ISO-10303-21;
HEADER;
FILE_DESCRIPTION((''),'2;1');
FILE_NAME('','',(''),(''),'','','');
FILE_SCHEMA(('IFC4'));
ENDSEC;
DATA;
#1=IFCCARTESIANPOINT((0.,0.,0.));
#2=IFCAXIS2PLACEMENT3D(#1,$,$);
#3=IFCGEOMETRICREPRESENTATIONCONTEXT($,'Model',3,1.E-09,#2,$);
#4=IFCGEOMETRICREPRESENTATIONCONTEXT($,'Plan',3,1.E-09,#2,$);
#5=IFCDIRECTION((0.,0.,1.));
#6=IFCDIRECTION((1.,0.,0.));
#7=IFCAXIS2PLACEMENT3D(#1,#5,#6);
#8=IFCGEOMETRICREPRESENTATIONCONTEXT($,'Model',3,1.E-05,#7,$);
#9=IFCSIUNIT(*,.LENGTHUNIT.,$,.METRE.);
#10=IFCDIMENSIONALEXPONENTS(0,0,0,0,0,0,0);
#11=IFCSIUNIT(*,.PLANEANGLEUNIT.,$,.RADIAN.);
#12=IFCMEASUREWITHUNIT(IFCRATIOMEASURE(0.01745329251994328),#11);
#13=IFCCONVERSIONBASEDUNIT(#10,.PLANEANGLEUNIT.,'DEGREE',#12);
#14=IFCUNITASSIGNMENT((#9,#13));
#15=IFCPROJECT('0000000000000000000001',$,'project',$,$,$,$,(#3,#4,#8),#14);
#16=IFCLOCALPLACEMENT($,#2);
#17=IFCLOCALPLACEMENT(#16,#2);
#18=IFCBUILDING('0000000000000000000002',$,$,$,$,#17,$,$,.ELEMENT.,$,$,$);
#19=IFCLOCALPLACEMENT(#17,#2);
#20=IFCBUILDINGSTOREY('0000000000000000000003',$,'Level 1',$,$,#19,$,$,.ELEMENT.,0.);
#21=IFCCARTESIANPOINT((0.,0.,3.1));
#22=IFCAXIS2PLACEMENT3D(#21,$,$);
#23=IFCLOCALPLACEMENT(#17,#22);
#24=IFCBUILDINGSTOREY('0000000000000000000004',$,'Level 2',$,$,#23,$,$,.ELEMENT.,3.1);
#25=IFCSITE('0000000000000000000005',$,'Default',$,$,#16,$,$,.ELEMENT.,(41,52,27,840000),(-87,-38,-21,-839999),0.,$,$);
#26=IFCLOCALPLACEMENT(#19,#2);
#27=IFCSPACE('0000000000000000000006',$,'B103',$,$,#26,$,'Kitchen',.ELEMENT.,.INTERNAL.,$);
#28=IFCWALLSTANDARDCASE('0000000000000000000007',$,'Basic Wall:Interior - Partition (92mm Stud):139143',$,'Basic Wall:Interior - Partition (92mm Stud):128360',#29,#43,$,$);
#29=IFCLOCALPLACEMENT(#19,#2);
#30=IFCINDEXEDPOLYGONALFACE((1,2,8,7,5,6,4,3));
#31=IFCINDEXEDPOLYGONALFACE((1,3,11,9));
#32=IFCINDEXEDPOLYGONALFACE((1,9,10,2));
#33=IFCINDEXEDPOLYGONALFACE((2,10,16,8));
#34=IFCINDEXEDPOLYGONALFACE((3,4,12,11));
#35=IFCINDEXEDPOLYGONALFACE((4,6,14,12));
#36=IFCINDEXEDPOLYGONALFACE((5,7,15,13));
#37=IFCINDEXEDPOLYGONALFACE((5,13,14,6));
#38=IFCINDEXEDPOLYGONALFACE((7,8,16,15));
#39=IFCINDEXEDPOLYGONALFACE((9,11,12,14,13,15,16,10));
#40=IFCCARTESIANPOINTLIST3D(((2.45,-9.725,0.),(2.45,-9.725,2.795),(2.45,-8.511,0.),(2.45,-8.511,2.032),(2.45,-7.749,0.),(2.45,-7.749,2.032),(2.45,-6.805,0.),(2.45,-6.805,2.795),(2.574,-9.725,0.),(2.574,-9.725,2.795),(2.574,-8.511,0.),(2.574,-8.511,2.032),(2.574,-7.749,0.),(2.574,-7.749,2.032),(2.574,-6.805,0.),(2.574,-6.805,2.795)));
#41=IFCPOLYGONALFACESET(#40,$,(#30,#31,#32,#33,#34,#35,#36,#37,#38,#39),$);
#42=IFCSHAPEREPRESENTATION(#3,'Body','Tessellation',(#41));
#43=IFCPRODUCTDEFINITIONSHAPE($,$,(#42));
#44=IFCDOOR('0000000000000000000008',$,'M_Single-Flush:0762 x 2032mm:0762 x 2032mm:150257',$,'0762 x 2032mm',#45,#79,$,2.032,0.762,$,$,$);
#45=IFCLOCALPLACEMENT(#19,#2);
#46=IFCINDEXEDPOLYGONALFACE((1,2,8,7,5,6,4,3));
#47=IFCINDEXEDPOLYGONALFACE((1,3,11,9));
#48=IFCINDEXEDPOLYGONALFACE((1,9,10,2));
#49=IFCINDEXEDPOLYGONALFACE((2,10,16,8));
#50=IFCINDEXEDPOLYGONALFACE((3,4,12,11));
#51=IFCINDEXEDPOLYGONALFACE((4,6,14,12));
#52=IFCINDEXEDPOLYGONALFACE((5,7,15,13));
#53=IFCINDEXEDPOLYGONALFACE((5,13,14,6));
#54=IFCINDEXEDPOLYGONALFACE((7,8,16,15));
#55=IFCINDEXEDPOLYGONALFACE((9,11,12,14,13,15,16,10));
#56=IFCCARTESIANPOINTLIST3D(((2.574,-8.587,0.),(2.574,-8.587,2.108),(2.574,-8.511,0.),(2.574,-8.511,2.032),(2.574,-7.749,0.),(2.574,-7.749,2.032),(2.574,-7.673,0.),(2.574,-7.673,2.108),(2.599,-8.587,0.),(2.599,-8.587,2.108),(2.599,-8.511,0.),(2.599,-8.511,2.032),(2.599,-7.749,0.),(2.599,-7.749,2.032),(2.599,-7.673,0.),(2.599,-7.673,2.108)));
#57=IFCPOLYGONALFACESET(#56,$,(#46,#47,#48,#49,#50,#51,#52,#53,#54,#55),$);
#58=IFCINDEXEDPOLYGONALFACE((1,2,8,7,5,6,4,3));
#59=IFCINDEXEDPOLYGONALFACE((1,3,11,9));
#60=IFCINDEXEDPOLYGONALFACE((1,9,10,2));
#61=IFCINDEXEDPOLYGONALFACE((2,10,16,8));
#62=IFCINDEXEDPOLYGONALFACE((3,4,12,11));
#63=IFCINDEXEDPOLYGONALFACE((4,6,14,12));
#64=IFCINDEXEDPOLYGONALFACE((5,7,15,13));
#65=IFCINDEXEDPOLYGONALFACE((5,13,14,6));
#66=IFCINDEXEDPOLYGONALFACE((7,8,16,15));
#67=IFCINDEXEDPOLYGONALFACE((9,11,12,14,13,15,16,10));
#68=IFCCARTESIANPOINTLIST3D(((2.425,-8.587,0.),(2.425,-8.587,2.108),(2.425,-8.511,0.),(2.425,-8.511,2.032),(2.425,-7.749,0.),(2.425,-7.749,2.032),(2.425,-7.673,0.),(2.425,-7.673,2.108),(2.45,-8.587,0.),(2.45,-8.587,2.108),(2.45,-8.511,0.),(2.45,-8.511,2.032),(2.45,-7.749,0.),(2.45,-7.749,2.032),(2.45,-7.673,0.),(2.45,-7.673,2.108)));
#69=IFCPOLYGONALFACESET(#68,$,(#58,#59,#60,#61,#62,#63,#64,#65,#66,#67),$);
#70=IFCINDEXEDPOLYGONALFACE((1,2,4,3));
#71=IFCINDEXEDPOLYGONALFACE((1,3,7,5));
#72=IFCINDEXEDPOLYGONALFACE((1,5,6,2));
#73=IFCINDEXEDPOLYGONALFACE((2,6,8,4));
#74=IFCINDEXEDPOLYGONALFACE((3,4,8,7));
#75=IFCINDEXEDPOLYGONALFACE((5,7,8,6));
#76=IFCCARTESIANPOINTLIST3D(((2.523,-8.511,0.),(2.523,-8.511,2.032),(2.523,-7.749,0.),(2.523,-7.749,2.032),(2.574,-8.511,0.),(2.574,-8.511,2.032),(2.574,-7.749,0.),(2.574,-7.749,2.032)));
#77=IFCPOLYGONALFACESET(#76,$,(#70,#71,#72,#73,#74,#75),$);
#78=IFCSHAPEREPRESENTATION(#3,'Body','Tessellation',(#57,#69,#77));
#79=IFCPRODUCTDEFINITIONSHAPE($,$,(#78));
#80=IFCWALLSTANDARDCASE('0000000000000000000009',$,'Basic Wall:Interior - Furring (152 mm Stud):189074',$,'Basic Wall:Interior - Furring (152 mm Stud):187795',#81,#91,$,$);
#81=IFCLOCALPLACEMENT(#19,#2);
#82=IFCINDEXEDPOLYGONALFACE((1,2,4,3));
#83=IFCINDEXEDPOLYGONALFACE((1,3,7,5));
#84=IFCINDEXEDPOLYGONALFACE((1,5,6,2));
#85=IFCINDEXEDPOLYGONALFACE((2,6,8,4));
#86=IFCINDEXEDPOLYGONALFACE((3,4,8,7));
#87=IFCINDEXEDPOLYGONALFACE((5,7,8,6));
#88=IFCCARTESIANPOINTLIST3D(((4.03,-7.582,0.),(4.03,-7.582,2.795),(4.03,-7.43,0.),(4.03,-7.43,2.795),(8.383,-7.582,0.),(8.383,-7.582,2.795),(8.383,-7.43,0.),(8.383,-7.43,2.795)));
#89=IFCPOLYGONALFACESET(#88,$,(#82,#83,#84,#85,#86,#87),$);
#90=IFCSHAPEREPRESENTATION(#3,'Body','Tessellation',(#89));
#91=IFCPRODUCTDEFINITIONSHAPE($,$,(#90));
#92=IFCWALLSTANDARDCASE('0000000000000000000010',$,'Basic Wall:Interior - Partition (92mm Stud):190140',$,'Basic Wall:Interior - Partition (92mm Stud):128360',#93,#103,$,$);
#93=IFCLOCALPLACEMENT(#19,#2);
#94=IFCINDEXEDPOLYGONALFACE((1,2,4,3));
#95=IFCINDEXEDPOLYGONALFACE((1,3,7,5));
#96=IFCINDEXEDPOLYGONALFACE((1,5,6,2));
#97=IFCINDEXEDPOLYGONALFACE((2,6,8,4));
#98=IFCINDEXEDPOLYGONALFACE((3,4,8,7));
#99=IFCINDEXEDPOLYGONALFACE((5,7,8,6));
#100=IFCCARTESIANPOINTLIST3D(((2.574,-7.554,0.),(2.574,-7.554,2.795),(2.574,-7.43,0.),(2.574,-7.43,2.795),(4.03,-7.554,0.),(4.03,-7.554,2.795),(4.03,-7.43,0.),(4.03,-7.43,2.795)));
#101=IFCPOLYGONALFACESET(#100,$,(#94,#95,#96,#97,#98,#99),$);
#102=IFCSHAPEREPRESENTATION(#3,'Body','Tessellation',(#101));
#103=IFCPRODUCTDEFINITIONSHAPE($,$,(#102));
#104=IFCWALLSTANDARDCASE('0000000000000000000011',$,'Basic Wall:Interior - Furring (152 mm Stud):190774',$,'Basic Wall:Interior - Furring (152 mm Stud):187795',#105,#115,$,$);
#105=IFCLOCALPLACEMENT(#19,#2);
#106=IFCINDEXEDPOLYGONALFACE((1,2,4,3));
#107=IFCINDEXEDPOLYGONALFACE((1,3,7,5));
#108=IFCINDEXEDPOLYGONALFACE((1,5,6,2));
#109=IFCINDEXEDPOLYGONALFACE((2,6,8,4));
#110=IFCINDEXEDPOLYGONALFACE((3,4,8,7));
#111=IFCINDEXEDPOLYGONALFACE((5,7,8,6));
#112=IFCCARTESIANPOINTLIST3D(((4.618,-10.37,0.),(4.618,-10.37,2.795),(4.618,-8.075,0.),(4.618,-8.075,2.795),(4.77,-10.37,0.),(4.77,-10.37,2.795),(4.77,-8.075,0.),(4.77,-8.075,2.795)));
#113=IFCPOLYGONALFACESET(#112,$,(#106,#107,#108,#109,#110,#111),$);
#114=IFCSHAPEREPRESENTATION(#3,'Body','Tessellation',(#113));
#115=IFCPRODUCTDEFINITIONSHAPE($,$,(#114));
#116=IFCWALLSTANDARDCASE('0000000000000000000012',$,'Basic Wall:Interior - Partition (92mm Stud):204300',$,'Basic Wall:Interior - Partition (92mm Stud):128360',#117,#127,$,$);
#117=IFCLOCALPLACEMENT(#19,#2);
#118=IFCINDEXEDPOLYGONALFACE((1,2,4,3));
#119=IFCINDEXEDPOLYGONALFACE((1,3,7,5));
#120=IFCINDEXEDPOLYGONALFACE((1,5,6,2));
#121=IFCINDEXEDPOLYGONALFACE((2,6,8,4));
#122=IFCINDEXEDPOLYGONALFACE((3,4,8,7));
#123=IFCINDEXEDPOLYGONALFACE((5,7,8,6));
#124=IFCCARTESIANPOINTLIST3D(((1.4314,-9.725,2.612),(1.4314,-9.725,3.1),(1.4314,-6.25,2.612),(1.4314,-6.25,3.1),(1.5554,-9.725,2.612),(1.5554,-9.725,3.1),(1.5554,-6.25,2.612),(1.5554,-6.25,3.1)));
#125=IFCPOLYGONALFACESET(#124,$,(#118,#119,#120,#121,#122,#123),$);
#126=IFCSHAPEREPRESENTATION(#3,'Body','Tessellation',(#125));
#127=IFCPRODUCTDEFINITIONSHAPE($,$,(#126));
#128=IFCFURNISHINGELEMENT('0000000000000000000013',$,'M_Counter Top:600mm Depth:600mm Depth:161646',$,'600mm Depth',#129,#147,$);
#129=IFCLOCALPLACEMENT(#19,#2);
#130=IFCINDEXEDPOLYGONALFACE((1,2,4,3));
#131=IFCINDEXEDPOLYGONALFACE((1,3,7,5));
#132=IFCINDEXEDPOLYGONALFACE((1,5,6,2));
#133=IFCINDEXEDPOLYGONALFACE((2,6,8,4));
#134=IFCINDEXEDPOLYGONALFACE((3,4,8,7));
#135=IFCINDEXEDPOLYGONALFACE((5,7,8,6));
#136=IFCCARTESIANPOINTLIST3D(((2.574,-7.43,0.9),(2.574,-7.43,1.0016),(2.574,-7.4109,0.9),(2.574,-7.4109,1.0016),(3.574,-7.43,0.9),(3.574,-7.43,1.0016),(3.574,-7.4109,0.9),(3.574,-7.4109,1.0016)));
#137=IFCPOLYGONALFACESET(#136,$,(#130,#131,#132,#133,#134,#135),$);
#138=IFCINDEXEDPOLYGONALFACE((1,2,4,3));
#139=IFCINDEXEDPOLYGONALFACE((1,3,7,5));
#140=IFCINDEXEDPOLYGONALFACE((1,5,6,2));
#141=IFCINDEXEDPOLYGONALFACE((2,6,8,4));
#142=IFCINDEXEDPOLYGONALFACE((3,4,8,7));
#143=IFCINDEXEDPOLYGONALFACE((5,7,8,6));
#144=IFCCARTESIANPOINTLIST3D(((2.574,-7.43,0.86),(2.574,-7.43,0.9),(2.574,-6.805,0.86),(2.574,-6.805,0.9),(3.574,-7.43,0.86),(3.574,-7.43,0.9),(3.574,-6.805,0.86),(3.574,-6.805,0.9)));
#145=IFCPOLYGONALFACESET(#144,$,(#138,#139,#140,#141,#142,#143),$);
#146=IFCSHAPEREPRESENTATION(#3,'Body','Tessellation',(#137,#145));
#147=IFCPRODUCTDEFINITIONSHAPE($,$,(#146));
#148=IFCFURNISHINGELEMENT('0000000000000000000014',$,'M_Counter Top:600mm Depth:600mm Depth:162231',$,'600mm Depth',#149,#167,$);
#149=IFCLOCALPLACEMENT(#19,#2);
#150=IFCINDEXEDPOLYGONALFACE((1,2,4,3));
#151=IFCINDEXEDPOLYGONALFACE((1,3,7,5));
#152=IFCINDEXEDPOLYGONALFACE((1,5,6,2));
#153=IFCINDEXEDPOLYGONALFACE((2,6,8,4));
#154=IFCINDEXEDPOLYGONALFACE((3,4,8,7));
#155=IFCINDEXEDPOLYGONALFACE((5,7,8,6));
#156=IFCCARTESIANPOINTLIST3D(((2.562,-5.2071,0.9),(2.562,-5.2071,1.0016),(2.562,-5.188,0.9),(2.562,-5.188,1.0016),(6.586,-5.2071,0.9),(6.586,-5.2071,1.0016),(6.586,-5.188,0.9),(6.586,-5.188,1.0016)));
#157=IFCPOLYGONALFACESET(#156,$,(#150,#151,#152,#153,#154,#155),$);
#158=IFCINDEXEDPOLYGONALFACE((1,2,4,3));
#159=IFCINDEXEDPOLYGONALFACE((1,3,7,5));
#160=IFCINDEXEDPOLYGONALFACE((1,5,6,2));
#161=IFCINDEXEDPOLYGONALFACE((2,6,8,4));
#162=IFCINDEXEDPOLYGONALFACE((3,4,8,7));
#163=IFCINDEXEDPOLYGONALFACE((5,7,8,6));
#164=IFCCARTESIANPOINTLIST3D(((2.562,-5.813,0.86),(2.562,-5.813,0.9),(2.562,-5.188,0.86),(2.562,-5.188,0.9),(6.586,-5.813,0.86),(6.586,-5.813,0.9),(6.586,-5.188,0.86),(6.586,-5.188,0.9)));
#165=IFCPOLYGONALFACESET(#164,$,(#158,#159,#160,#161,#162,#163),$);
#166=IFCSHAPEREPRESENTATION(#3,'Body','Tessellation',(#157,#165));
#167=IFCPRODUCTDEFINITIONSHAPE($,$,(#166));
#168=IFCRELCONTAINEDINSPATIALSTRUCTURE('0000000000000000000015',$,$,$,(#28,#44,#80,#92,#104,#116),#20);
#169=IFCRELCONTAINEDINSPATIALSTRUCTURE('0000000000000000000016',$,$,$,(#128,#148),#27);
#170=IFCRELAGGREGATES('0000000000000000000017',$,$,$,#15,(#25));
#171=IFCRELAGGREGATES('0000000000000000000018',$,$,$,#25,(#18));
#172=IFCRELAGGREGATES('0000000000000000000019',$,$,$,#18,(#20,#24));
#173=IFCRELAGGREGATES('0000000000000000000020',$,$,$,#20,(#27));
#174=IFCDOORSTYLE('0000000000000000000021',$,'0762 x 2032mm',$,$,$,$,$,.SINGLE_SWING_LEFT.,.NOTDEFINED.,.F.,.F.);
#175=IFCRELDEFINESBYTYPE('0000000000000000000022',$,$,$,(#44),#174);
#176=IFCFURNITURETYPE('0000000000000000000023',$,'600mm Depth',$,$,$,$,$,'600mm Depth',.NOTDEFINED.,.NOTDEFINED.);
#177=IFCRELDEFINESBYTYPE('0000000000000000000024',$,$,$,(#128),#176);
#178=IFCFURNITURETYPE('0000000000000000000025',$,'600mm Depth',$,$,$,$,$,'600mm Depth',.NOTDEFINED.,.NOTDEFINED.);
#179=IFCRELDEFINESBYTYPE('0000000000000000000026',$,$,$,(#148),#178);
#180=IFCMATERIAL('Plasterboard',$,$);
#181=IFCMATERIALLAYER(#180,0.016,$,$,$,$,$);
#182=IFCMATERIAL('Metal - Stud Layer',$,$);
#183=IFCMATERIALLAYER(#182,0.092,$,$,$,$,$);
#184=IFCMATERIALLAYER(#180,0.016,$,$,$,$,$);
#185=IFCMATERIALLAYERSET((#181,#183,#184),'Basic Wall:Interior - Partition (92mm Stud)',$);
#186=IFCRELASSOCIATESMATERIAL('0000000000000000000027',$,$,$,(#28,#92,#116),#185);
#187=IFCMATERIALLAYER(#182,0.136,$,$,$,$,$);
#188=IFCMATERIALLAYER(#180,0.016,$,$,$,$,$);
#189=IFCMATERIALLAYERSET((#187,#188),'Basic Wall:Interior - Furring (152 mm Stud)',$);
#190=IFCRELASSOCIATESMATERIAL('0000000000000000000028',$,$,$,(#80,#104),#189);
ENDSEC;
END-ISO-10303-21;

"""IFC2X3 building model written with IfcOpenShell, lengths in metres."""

from ifc_helpers import new_model, entity, si_unit, converted_unit, frame, frame_2d, origin, origin_with_axes, origin_2d_with_axis, place, context, project, spatial, polyline, rectangle, outline, extrude, clip, bounded_halfspace, source, transform, mapped, material, layer, layer_set, layer_usage, type_object, type_shapes, element, fill, save


model = new_model("IFC2X3")

# Units and contexts
model_context_1 = context("Model", 3, precision=1e-09, world=origin())
plan_context = context("Plan", 3, precision=1e-09, world=origin())
model_context_2 = context("Model", 3, precision=1e-05, world=origin_with_axes())
ifc_project = project(units=[si_unit("LENGTHUNIT", "METRE"), converted_unit("PLANEANGLEUNIT", "DEGREE", entity("IfcRatioMeasure", 0.01745329251994328), si_unit("PLANEANGLEUNIT", "RADIAN"), dimensions=[0, 0, 0, 0, 0, 0, 0])], contexts=[model_context_1, plan_context, model_context_2])

# Site, building, storey
site_placement = place(None, origin())
site = spatial("IfcSite", under=ifc_project, at=site_placement, Name="Default", CompositionType="ELEMENT", RefLatitude=(41, 52, 27, 840000), RefLongitude=(-87, -38, -21, -839999), RefElevation=0.0)
building_placement = place(site_placement, origin())
building = spatial("IfcBuilding", under=site, at=building_placement, CompositionType="ELEMENT")
storey_1_placement = place(building_placement, origin())
storey_1 = spatial("IfcBuildingStorey", under=building, at=storey_1_placement, Name="Level 1", CompositionType="ELEMENT", Elevation=0.0)

# Shared definitions
ifc_material_1 = material(Name="Metal - Stud Layer")
ifc_material_2 = material(Name="Plasterboard")

# Shared definitions
ifc_layer_1 = layer(ifc_material_2, 0.016)
ifc_layer_2 = layer(ifc_material_1, 0.092)
ifc_layer_3 = layer(ifc_material_2, 0.016)
ifc_layer_set_1 = layer_set([ifc_layer_1, ifc_layer_2, ifc_layer_3], Name="Basic Wall:Interior - Partition (92mm Stud)")

# Wall, opening, door
ifc_layer_usage_1 = layer_usage(ifc_layer_set_1, "AXIS2", "NEGATIVE", 0.062)
wall_1_placement = place(storey_1_placement, frame((2.512, -6.805, 0.0), z_axis=(0.0, 0.0, 1.0), x_axis=(0.0, -1.0, 0.0)))
wall_1 = element("IfcWallStandardCase", 1, at=wall_1_placement, inside=storey_1, material=ifc_layer_usage_1, Name="Basic Wall:Interior - Partition (92mm Stud):139143", ObjectType="Basic Wall:Interior - Partition (92mm Stud):128360", context=model_context_1, shape_type="SweptSolid", body=[
    extrude(rectangle(XDim=2.92, YDim=0.124, at=frame_2d((1.46, 0.0), x_axis=(-1.0, 0.0))), origin(), (0.0, 0.0, 1.0), 2.795),
])
opening_1_placement = place(wall_1_placement, frame((0.944, -0.062, 0.0)))
opening_1 = element("IfcOpeningElement", 2, at=opening_1_placement, cuts=wall_1, ObjectType="Opening", context=model_context_1, shape_type="SweptSolid", body=[
    extrude(rectangle(XDim=0.762, YDim=2.032, at=frame_2d((1.016, 0.381), x_axis=(0.0, -1.0))), frame((0.0, 0.0, 0.0), z_axis=(0.0, 1.0, 0.0), x_axis=(0.0, 0.0, 1.0)), (0.0, 0.0, 1.0), 0.124),
])
door_style_1 = type_object("IfcDoorStyle", Name="0762 x 2032mm", ConstructionType="NOTDEFINED", OperationType="SINGLE_SWING_LEFT", ParameterTakesPrecedence=False, Sizeable=False)
shared_shape_1 = source(origin(), model_context_1, "Body", "SweptSolid", [
    extrude(outline(polyline([(-0.457, -1.073), (0.457, -1.073), (0.457, 1.035), (0.381, 1.035), (0.381, -0.997), (-0.381, -0.997), (-0.381, 1.035), (-0.457, 1.035), (-0.457, -1.073)])), frame((0.381, 0.149, 1.035), z_axis=(0.0, -1.0, 0.0), x_axis=(-1.0, 0.0, 0.0)), (0.0, 0.0, 1.0), 0.025),
    extrude(outline(polyline([(-1.073, -0.457), (1.035, -0.457), (1.035, -0.381), (-0.997, -0.381), (-0.997, 0.381), (1.035, 0.381), (1.035, 0.457), (-1.073, 0.457), (-1.073, -0.457)])), frame((0.381, 0.0, 1.035), z_axis=(0.0, -1.0, 0.0), x_axis=(0.0, 0.0, -1.0)), (0.0, 0.0, 1.0), 0.025),
    extrude(rectangle(XDim=0.762, YDim=0.051, at=origin_2d_with_axis()), frame((0.381, 0.0985, 0.0)), (0.0, 0.0, 1.0), 2.032),
])
type_shapes(door_style_1, [shared_shape_1])
door_1_placement = place(opening_1_placement, origin())
door_1 = element("IfcDoor", 3, at=door_1_placement, inside=storey_1, type_object=door_style_1, Name="M_Single-Flush:0762 x 2032mm:0762 x 2032mm:150257", ObjectType="0762 x 2032mm", OverallHeight=2.032, OverallWidth=0.762, context=model_context_1, shape_type="MappedRepresentation", body=[
    mapped(shared_shape_1, transform((0.0, 0.0, 0.0), scale=1.0)),
])
fill(opening_1, door_1)

# Shared definitions
storey_2_placement = place(building_placement, frame((0.0, 0.0, 3.1)))
storey_2 = spatial("IfcBuildingStorey", under=building, at=storey_2_placement, Name="Level 2", CompositionType="ELEMENT", Elevation=3.1)

# Walls
ifc_layer_4 = layer(ifc_material_1, 0.136)
ifc_layer_5 = layer(ifc_material_2, 0.016)
ifc_layer_set_2 = layer_set([ifc_layer_4, ifc_layer_5], Name="Basic Wall:Interior - Furring (152 mm Stud)")
ifc_layer_usage_2 = layer_usage(ifc_layer_set_2, "AXIS2", "NEGATIVE", 0.076)
wall_2_placement = place(storey_1_placement, frame((8.383, -7.506, 0.0), z_axis=(0.0, 0.0, 1.0), x_axis=(-1.0, 0.0, 0.0)))
element("IfcWallStandardCase", 4, at=wall_2_placement, inside=storey_1, material=ifc_layer_usage_2, Name="Basic Wall:Interior - Furring (152 mm Stud):189074", ObjectType="Basic Wall:Interior - Furring (152 mm Stud):187795", context=model_context_1, shape_type="Clipping", body=[
    clip(extrude(rectangle(XDim=4.353, YDim=0.152, at=frame_2d((2.1765, 0.0), x_axis=(-1.0, 0.0))), origin(), (0.0, 0.0, 1.0), 2.795), bounded_halfspace(frame((0.0, -0.076, 2.795), z_axis=(0.0, 0.0, -1.0), x_axis=(0.0, 1.0, 0.0)), True, frame((0.0, -0.076, 2.795)), polyline([(0.0, 0.0), (3.708, 0.0), (3.708, 0.152), (0.0, 0.152), (0.0, 0.0)]))),
])
ifc_layer_usage_3 = layer_usage(ifc_layer_set_1, "AXIS2", "NEGATIVE", 0.062)
wall_3_placement = place(storey_1_placement, frame((4.03, -7.492, 0.0), z_axis=(0.0, 0.0, 1.0), x_axis=(-1.0, 0.0, 0.0)))
element("IfcWallStandardCase", 5, at=wall_3_placement, inside=storey_1, material=ifc_layer_usage_3, Name="Basic Wall:Interior - Partition (92mm Stud):190140", ObjectType="Basic Wall:Interior - Partition (92mm Stud):128360", context=model_context_1, shape_type="SweptSolid", body=[
    extrude(rectangle(XDim=1.456, YDim=0.124, at=frame_2d((0.728, 0.0), x_axis=(-1.0, 0.0))), origin(), (0.0, 0.0, 1.0), 2.795),
])
ifc_layer_usage_4 = layer_usage(ifc_layer_set_2, "AXIS2", "POSITIVE", -0.076)
wall_4_placement = place(storey_1_placement, frame((4.694, -8.075, 0.0), z_axis=(0.0, 0.0, 1.0), x_axis=(0.0, -1.0, 0.0)))
element("IfcWallStandardCase", 6, at=wall_4_placement, inside=storey_1, material=ifc_layer_usage_4, Name="Basic Wall:Interior - Furring (152 mm Stud):190774", ObjectType="Basic Wall:Interior - Furring (152 mm Stud):187795", context=model_context_1, shape_type="SweptSolid", body=[
    extrude(rectangle(XDim=2.295, YDim=0.152, at=frame_2d((1.1475, 0.0), x_axis=(-1.0, 0.0))), origin(), (0.0, 0.0, 1.0), 2.795),
])
ifc_layer_usage_5 = layer_usage(ifc_layer_set_1, "AXIS2", "NEGATIVE", 0.062)
wall_5_placement = place(storey_1_placement, frame((1.4934, -6.25, 2.612), z_axis=(0.0, 0.0, 1.0), x_axis=(0.0, -1.0, 0.0)))
element("IfcWallStandardCase", 7, at=wall_5_placement, inside=storey_1, material=ifc_layer_usage_5, Name="Basic Wall:Interior - Partition (92mm Stud):204300", ObjectType="Basic Wall:Interior - Partition (92mm Stud):128360", context=model_context_1, shape_type="SweptSolid", body=[
    extrude(rectangle(XDim=3.475, YDim=0.124, at=frame_2d((1.7375, 0.0), x_axis=(-1.0, 0.0))), origin(), (0.0, 0.0, 1.0), 0.488),
])

# Shared definitions
space_1_placement = place(storey_1_placement, origin())
space_1 = spatial("IfcSpace", under=storey_1, at=space_1_placement, Name="B103", LongName="Kitchen", CompositionType="ELEMENT", InteriorOrExteriorSpace="INTERNAL")

# Furnishing elements
furniture_type_1 = type_object("IfcFurnitureType", Name="600mm Depth", ElementType="600mm Depth", AssemblyPlace="NOTDEFINED")
shared_shape_2 = source(origin(), model_context_1, "Body", "SweptSolid", [
    extrude(rectangle(XDim=0.0191, YDim=1.0, at=origin_2d_with_axis()), frame((-0.7005, -0.0095, 0.9), z_axis=(0.0, 0.0, 1.0), x_axis=(0.0, -1.0, 0.0)), (0.0, 0.0, 1.0), 0.1016),
    extrude(rectangle(XDim=1.0, YDim=0.625, at=origin_2d_with_axis()), frame((-0.7005, -0.3125, 0.86), z_axis=(0.0, 0.0, 1.0), x_axis=(-1.0, 0.0, 0.0)), (0.0, 0.0, 1.0), 0.04),
])
type_shapes(furniture_type_1, [shared_shape_2])
furnishing_1_placement = place(space_1_placement, frame((2.3735, -7.43, 0.0), z_axis=(0.0, 0.0, 1.0), x_axis=(-1.0, 0.0, 0.0)))
element("IfcFurnishingElement", 8, at=furnishing_1_placement, inside=space_1, type_object=furniture_type_1, Name="M_Counter Top:600mm Depth:600mm Depth:161646", ObjectType="600mm Depth", context=model_context_1, shape_type="MappedRepresentation", body=[
    mapped(shared_shape_2, transform((0.0, 0.0, 0.0), scale=1.0)),
])
furniture_type_2 = type_object("IfcFurnitureType", Name="600mm Depth", ElementType="600mm Depth", AssemblyPlace="NOTDEFINED")
shared_shape_3 = source(origin(), model_context_1, "Body", "SweptSolid", [
    extrude(rectangle(XDim=0.0191, YDim=4.024, at=origin_2d_with_axis()), frame((0.8115, -0.0095, 0.9), z_axis=(0.0, 0.0, 1.0), x_axis=(0.0, -1.0, 0.0)), (0.0, 0.0, 1.0), 0.1016),
    extrude(rectangle(XDim=4.024, YDim=0.625, at=origin_2d_with_axis()), frame((0.8115, -0.3125, 0.86), z_axis=(0.0, 0.0, 1.0), x_axis=(-1.0, 0.0, 0.0)), (0.0, 0.0, 1.0), 0.04),
])
type_shapes(furniture_type_2, [shared_shape_3])
furnishing_2_placement = place(space_1_placement, frame((3.7625, -5.188, 0.0)))
element("IfcFurnishingElement", 9, at=furnishing_2_placement, inside=space_1, type_object=furniture_type_2, Name="M_Counter Top:600mm Depth:600mm Depth:162231", ObjectType="600mm Depth", context=model_context_1, shape_type="MappedRepresentation", body=[
    mapped(shared_shape_3, transform((0.0, 0.0, 0.0), scale=1.0)),
])

save(model, "model.ifc")
